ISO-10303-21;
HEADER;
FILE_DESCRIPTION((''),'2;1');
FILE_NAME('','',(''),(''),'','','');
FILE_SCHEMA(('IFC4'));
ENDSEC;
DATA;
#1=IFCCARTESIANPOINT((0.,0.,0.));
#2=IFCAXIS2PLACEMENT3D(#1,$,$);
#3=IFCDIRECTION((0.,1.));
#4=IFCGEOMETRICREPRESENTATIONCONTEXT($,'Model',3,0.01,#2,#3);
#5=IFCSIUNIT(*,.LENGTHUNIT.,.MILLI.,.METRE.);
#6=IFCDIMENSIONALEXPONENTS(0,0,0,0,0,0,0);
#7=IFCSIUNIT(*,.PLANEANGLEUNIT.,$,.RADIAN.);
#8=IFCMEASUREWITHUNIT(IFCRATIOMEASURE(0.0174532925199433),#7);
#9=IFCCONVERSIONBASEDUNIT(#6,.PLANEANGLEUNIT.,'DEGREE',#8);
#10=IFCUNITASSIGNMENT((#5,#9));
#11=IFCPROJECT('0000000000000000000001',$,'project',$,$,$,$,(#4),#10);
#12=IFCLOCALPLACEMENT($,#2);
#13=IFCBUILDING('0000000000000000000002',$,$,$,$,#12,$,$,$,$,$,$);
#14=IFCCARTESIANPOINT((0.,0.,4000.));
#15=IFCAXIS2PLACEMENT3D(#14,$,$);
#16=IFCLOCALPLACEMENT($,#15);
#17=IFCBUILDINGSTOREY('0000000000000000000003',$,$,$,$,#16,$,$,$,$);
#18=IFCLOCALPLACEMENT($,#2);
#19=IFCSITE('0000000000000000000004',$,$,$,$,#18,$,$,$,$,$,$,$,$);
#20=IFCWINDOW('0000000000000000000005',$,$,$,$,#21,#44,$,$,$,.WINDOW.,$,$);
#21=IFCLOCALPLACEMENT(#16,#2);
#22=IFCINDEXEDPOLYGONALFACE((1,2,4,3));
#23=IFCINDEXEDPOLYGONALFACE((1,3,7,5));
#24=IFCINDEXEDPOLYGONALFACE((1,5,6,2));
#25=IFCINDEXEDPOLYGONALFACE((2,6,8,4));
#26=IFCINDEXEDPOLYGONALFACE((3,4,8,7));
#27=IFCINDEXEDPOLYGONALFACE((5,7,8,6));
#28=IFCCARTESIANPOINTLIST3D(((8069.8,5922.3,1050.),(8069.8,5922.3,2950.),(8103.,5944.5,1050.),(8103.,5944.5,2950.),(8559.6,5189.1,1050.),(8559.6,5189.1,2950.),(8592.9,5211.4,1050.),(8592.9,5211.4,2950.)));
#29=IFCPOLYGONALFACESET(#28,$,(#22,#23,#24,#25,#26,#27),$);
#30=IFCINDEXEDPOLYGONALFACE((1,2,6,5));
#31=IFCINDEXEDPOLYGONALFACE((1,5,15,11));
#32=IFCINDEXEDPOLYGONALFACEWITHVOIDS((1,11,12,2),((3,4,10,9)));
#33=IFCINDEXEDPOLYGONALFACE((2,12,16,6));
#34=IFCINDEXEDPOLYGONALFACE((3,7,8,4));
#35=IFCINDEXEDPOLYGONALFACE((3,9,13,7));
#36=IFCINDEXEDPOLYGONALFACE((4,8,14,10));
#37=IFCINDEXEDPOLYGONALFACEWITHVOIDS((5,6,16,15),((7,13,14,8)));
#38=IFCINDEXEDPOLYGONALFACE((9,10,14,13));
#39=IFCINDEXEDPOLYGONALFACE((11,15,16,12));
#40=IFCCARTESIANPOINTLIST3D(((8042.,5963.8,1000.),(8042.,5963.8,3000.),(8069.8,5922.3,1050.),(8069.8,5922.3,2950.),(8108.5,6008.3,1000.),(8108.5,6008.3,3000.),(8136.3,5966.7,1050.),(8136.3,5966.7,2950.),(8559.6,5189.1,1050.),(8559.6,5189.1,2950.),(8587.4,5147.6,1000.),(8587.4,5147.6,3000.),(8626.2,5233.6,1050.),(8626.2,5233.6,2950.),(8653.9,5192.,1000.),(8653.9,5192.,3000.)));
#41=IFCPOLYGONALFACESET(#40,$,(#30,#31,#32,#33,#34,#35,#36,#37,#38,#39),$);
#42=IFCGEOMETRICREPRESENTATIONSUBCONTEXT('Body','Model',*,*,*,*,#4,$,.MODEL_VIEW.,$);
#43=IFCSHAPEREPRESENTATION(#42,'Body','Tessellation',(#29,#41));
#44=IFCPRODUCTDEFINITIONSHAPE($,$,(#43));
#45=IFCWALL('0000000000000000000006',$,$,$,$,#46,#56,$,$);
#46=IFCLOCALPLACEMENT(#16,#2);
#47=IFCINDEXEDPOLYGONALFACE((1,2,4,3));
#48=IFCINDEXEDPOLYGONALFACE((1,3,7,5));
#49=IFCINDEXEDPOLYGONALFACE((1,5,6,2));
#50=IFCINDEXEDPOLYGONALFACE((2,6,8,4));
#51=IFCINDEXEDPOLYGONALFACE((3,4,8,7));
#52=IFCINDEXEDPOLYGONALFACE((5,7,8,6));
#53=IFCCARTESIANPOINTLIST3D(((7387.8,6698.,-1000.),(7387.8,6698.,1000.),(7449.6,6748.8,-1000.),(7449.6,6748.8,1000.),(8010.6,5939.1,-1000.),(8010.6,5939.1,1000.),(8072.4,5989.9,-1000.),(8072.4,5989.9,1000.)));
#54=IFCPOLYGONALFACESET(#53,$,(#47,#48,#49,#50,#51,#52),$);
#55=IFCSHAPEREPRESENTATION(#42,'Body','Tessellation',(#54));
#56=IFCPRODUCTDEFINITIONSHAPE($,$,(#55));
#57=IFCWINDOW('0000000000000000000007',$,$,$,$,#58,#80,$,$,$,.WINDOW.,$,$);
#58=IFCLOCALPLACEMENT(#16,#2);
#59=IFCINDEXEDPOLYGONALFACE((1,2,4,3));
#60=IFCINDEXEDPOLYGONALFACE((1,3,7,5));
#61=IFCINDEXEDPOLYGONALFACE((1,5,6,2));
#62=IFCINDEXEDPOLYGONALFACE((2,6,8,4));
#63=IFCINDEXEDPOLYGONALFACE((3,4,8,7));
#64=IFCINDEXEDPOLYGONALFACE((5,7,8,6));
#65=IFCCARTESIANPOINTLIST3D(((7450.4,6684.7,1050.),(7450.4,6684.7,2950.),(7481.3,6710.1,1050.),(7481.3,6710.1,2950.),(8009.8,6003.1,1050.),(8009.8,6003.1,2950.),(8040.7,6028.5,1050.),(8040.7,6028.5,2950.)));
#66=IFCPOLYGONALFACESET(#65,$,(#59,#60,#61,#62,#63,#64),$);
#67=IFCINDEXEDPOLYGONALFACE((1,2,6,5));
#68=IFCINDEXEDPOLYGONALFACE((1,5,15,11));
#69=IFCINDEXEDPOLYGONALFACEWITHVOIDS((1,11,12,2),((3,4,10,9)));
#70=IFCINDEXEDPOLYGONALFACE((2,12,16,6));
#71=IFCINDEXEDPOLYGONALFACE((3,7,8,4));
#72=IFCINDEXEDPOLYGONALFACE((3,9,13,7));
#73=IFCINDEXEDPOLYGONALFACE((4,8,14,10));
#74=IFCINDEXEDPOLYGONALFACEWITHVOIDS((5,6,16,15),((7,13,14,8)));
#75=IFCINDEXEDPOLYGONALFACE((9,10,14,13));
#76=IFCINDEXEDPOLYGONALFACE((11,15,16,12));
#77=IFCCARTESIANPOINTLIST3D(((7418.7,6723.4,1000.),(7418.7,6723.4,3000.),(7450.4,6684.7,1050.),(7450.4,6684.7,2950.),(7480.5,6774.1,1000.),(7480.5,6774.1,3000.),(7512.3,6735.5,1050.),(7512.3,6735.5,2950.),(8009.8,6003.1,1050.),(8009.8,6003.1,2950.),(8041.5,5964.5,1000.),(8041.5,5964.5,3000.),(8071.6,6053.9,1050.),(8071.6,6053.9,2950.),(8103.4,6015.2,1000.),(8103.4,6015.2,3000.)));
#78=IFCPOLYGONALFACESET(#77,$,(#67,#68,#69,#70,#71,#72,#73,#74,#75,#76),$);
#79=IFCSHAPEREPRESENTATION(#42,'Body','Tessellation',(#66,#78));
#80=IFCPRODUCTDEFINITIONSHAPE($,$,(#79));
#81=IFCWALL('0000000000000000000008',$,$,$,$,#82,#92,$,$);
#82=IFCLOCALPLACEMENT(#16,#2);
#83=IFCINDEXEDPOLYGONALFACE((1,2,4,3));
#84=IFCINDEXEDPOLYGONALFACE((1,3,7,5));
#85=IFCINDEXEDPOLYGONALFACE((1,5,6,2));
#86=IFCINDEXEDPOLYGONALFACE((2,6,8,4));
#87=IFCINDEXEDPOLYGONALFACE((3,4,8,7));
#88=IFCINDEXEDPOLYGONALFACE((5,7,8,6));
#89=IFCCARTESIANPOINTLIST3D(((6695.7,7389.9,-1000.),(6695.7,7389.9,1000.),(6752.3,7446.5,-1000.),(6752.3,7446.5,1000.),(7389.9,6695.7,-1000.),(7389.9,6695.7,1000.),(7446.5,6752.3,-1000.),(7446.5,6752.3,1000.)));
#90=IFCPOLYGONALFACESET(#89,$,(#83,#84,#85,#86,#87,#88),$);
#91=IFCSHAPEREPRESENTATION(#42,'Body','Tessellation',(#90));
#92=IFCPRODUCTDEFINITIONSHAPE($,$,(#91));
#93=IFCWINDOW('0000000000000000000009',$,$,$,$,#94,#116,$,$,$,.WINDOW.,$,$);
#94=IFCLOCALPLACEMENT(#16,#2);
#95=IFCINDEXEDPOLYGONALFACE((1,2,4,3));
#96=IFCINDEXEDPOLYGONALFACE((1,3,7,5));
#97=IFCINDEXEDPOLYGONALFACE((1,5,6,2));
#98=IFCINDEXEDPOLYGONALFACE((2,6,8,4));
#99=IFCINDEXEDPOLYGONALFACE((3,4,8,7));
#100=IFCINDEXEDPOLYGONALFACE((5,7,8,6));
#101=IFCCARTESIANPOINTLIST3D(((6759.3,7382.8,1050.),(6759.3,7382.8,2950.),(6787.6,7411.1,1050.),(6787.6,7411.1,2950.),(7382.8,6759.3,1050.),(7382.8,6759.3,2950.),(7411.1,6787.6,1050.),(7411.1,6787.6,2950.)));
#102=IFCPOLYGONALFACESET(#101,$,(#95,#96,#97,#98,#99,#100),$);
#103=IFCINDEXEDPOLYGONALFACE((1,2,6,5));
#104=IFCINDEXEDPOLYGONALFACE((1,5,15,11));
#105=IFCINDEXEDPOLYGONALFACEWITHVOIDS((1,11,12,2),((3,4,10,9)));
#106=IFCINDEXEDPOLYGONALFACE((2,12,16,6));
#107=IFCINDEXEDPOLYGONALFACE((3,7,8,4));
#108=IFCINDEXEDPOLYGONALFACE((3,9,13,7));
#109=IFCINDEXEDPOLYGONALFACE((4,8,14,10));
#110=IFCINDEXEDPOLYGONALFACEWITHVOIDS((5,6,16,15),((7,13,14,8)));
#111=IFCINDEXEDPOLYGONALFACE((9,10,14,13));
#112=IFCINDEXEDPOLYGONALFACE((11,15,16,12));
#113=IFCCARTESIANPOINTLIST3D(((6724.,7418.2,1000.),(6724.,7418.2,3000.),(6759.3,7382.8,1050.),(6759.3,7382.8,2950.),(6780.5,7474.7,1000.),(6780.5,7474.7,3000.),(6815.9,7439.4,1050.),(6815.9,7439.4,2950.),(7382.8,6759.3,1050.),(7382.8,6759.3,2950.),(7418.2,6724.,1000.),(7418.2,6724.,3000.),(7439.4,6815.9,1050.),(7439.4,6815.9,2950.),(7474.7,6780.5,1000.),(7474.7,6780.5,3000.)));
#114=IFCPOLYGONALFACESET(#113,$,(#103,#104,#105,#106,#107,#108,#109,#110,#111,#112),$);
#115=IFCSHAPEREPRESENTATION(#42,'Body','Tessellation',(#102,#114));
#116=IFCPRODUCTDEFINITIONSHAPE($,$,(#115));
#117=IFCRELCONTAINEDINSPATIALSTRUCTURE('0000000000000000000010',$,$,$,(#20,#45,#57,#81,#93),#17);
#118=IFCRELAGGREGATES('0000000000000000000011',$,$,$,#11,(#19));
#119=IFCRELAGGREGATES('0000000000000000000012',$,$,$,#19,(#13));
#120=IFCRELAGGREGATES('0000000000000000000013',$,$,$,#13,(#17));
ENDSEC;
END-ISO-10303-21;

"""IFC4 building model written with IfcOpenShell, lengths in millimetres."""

from ifc_helpers import new_model, entity, si_unit, converted_unit, direction, frame, origin, origin_2d, place, context, subcontext, project, spatial, rectangle, extrude, element, save


model = new_model("IFC4")

# Units and contexts
model_context = context("Model", 3, precision=0.01, world=origin(), true_north=direction((0.0, 1.0)))
body_context = subcontext(model_context, "Body", "Model", "MODEL_VIEW")
ifc_project = project(units=[si_unit("LENGTHUNIT", "METRE", prefix="MILLI"), converted_unit("PLANEANGLEUNIT", "DEGREE", entity("IfcRatioMeasure", 0.0174532925199433), si_unit("PLANEANGLEUNIT", "RADIAN"), dimensions=[0, 0, 0, 0, 0, 0, 0])], contexts=[model_context])

# Site, building, storey
site_placement = place(None, origin())
site = spatial("IfcSite", under=ifc_project, at=site_placement)
building_placement = place(None, origin())
building = spatial("IfcBuilding", under=site, at=building_placement)
storey_placement = place(None, frame((0.0, 0.0, 4000.0)))
storey = spatial("IfcBuildingStorey", under=building, at=storey_placement)

# Shared definitions
cartesian_point_1 = entity("IfcCartesianPoint", [-440.9, -950.0])
shared_polyline = entity("IfcPolyline", [cartesian_point_1, entity("IfcCartesianPoint", [-440.9, 950.0]), entity("IfcCartesianPoint", [-440.9, 950.0]), entity("IfcCartesianPoint", [440.9, 950.0]), entity("IfcCartesianPoint", [440.9, 950.0]), entity("IfcCartesianPoint", [440.9, -950.0]), entity("IfcCartesianPoint", [440.9, -950.0]), entity("IfcCartesianPoint", [-440.9, -950.0]), cartesian_point_1])

# Window
window_1_placement = place(storey_placement, frame((8314.7, 5555.7, 2000.0), z_axis=(0.0, 0.0, 1.0), x_axis=(-5555.702343, 8314.696115, 0.0)))
cartesian_point_2 = entity("IfcCartesianPoint", [-490.9, -1000.0])
element("IfcWindow", 1, at=window_1_placement, inside=storey, PredefinedType="WINDOW", context=body_context, shape_type="SweptSolid", body=[
    entity("IfcExtrudedAreaSolid", entity("IfcArbitraryClosedProfileDef", "AREA", None, shared_polyline), entity("IfcAxis2Placement3D", entity("IfcCartesianPoint", [0.0, 0.0, 0.0]), entity("IfcDirection", [0.0, -1.0, 0.0]), entity("IfcDirection", [1.0, 0.0, 0.0])), entity("IfcDirection", [0.0, 0.0, 1.0]), 40.0),
    entity("IfcExtrudedAreaSolid", entity("IfcArbitraryProfileDefWithVoids", "AREA", None, entity("IfcPolyline", [cartesian_point_2, entity("IfcCartesianPoint", [-490.9, 1000.0]), entity("IfcCartesianPoint", [-490.9, 1000.0]), entity("IfcCartesianPoint", [490.9, 1000.0]), entity("IfcCartesianPoint", [490.9, 1000.0]), entity("IfcCartesianPoint", [490.9, -1000.0]), entity("IfcCartesianPoint", [490.9, -1000.0]), entity("IfcCartesianPoint", [-490.9, -1000.0]), cartesian_point_2]), [shared_polyline]), entity("IfcAxis2Placement3D", entity("IfcCartesianPoint", [0.0, 0.0, 0.0]), entity("IfcDirection", [0.0, -1.0, 0.0]), entity("IfcDirection", [1.0, 0.0, 0.0])), entity("IfcDirection", [0.0, 0.0, 1.0]), 80.0),
])

# Wall
wall_1_placement = place(storey_placement, frame((7730.1, 6343.9, -1000.0), z_axis=(0.0, 0.0, 1.0), x_axis=(-6343.932701, 7730.104649, 0.0)))
element("IfcWall", 2, at=wall_1_placement, inside=storey, context=body_context, shape_type="SweptSolid", body=[
    extrude(rectangle(XDim=981.7, YDim=80.0, at=origin_2d()), origin(), (0.0, 0.0, 1.0), 2000.0),
])

# Window
window_2_placement = place(storey_placement, frame((7730.1, 6343.9, 2000.0), z_axis=(0.0, 0.0, 1.0), x_axis=(-6343.932701, 7730.104649, 0.0)))
cartesian_point_3 = entity("IfcCartesianPoint", [-490.9, -1000.0])
element("IfcWindow", 3, at=window_2_placement, inside=storey, PredefinedType="WINDOW", context=body_context, shape_type="SweptSolid", body=[
    entity("IfcExtrudedAreaSolid", entity("IfcArbitraryClosedProfileDef", "AREA", None, shared_polyline), entity("IfcAxis2Placement3D", entity("IfcCartesianPoint", [0.0, 0.0, 0.0]), entity("IfcDirection", [0.0, -1.0, 0.0]), entity("IfcDirection", [1.0, 0.0, 0.0])), entity("IfcDirection", [0.0, 0.0, 1.0]), 40.0),
    entity("IfcExtrudedAreaSolid", entity("IfcArbitraryProfileDefWithVoids", "AREA", None, entity("IfcPolyline", [cartesian_point_3, entity("IfcCartesianPoint", [-490.9, 1000.0]), entity("IfcCartesianPoint", [-490.9, 1000.0]), entity("IfcCartesianPoint", [490.9, 1000.0]), entity("IfcCartesianPoint", [490.9, 1000.0]), entity("IfcCartesianPoint", [490.9, -1000.0]), entity("IfcCartesianPoint", [490.9, -1000.0]), entity("IfcCartesianPoint", [-490.9, -1000.0]), cartesian_point_3]), [shared_polyline]), entity("IfcAxis2Placement3D", entity("IfcCartesianPoint", [0.0, 0.0, 0.0]), entity("IfcDirection", [0.0, -1.0, 0.0]), entity("IfcDirection", [1.0, 0.0, 0.0])), entity("IfcDirection", [0.0, 0.0, 1.0]), 80.0),
])

# Wall
wall_2_placement = place(storey_placement, frame((7071.1, 7071.1, -1000.0), z_axis=(0.0, 0.0, 1.0), x_axis=(-7071.067966, 7071.067657, 0.0)))
element("IfcWall", 4, at=wall_2_placement, inside=storey, context=body_context, shape_type="SweptSolid", body=[
    extrude(rectangle(XDim=981.7, YDim=80.0, at=origin_2d()), origin(), (0.0, 0.0, 1.0), 2000.0),
])

# Window
window_3_placement = place(storey_placement, frame((7071.1, 7071.1, 2000.0), z_axis=(0.0, 0.0, 1.0), x_axis=(-7071.067966, 7071.067657, 0.0)))
cartesian_point_4 = entity("IfcCartesianPoint", [-490.9, -1000.0])
element("IfcWindow", 5, at=window_3_placement, inside=storey, PredefinedType="WINDOW", context=body_context, shape_type="SweptSolid", body=[
    entity("IfcExtrudedAreaSolid", entity("IfcArbitraryClosedProfileDef", "AREA", None, shared_polyline), entity("IfcAxis2Placement3D", entity("IfcCartesianPoint", [0.0, 0.0, 0.0]), entity("IfcDirection", [0.0, -1.0, 0.0]), entity("IfcDirection", [1.0, 0.0, 0.0])), entity("IfcDirection", [0.0, 0.0, 1.0]), 40.0),
    entity("IfcExtrudedAreaSolid", entity("IfcArbitraryProfileDefWithVoids", "AREA", None, entity("IfcPolyline", [cartesian_point_4, entity("IfcCartesianPoint", [-490.9, 1000.0]), entity("IfcCartesianPoint", [-490.9, 1000.0]), entity("IfcCartesianPoint", [490.9, 1000.0]), entity("IfcCartesianPoint", [490.9, 1000.0]), entity("IfcCartesianPoint", [490.9, -1000.0]), entity("IfcCartesianPoint", [490.9, -1000.0]), entity("IfcCartesianPoint", [-490.9, -1000.0]), cartesian_point_4]), [shared_polyline]), entity("IfcAxis2Placement3D", entity("IfcCartesianPoint", [0.0, 0.0, 0.0]), entity("IfcDirection", [0.0, -1.0, 0.0]), entity("IfcDirection", [1.0, 0.0, 0.0])), entity("IfcDirection", [0.0, 0.0, 1.0]), 80.0),
])

save(model, "model.ifc")
